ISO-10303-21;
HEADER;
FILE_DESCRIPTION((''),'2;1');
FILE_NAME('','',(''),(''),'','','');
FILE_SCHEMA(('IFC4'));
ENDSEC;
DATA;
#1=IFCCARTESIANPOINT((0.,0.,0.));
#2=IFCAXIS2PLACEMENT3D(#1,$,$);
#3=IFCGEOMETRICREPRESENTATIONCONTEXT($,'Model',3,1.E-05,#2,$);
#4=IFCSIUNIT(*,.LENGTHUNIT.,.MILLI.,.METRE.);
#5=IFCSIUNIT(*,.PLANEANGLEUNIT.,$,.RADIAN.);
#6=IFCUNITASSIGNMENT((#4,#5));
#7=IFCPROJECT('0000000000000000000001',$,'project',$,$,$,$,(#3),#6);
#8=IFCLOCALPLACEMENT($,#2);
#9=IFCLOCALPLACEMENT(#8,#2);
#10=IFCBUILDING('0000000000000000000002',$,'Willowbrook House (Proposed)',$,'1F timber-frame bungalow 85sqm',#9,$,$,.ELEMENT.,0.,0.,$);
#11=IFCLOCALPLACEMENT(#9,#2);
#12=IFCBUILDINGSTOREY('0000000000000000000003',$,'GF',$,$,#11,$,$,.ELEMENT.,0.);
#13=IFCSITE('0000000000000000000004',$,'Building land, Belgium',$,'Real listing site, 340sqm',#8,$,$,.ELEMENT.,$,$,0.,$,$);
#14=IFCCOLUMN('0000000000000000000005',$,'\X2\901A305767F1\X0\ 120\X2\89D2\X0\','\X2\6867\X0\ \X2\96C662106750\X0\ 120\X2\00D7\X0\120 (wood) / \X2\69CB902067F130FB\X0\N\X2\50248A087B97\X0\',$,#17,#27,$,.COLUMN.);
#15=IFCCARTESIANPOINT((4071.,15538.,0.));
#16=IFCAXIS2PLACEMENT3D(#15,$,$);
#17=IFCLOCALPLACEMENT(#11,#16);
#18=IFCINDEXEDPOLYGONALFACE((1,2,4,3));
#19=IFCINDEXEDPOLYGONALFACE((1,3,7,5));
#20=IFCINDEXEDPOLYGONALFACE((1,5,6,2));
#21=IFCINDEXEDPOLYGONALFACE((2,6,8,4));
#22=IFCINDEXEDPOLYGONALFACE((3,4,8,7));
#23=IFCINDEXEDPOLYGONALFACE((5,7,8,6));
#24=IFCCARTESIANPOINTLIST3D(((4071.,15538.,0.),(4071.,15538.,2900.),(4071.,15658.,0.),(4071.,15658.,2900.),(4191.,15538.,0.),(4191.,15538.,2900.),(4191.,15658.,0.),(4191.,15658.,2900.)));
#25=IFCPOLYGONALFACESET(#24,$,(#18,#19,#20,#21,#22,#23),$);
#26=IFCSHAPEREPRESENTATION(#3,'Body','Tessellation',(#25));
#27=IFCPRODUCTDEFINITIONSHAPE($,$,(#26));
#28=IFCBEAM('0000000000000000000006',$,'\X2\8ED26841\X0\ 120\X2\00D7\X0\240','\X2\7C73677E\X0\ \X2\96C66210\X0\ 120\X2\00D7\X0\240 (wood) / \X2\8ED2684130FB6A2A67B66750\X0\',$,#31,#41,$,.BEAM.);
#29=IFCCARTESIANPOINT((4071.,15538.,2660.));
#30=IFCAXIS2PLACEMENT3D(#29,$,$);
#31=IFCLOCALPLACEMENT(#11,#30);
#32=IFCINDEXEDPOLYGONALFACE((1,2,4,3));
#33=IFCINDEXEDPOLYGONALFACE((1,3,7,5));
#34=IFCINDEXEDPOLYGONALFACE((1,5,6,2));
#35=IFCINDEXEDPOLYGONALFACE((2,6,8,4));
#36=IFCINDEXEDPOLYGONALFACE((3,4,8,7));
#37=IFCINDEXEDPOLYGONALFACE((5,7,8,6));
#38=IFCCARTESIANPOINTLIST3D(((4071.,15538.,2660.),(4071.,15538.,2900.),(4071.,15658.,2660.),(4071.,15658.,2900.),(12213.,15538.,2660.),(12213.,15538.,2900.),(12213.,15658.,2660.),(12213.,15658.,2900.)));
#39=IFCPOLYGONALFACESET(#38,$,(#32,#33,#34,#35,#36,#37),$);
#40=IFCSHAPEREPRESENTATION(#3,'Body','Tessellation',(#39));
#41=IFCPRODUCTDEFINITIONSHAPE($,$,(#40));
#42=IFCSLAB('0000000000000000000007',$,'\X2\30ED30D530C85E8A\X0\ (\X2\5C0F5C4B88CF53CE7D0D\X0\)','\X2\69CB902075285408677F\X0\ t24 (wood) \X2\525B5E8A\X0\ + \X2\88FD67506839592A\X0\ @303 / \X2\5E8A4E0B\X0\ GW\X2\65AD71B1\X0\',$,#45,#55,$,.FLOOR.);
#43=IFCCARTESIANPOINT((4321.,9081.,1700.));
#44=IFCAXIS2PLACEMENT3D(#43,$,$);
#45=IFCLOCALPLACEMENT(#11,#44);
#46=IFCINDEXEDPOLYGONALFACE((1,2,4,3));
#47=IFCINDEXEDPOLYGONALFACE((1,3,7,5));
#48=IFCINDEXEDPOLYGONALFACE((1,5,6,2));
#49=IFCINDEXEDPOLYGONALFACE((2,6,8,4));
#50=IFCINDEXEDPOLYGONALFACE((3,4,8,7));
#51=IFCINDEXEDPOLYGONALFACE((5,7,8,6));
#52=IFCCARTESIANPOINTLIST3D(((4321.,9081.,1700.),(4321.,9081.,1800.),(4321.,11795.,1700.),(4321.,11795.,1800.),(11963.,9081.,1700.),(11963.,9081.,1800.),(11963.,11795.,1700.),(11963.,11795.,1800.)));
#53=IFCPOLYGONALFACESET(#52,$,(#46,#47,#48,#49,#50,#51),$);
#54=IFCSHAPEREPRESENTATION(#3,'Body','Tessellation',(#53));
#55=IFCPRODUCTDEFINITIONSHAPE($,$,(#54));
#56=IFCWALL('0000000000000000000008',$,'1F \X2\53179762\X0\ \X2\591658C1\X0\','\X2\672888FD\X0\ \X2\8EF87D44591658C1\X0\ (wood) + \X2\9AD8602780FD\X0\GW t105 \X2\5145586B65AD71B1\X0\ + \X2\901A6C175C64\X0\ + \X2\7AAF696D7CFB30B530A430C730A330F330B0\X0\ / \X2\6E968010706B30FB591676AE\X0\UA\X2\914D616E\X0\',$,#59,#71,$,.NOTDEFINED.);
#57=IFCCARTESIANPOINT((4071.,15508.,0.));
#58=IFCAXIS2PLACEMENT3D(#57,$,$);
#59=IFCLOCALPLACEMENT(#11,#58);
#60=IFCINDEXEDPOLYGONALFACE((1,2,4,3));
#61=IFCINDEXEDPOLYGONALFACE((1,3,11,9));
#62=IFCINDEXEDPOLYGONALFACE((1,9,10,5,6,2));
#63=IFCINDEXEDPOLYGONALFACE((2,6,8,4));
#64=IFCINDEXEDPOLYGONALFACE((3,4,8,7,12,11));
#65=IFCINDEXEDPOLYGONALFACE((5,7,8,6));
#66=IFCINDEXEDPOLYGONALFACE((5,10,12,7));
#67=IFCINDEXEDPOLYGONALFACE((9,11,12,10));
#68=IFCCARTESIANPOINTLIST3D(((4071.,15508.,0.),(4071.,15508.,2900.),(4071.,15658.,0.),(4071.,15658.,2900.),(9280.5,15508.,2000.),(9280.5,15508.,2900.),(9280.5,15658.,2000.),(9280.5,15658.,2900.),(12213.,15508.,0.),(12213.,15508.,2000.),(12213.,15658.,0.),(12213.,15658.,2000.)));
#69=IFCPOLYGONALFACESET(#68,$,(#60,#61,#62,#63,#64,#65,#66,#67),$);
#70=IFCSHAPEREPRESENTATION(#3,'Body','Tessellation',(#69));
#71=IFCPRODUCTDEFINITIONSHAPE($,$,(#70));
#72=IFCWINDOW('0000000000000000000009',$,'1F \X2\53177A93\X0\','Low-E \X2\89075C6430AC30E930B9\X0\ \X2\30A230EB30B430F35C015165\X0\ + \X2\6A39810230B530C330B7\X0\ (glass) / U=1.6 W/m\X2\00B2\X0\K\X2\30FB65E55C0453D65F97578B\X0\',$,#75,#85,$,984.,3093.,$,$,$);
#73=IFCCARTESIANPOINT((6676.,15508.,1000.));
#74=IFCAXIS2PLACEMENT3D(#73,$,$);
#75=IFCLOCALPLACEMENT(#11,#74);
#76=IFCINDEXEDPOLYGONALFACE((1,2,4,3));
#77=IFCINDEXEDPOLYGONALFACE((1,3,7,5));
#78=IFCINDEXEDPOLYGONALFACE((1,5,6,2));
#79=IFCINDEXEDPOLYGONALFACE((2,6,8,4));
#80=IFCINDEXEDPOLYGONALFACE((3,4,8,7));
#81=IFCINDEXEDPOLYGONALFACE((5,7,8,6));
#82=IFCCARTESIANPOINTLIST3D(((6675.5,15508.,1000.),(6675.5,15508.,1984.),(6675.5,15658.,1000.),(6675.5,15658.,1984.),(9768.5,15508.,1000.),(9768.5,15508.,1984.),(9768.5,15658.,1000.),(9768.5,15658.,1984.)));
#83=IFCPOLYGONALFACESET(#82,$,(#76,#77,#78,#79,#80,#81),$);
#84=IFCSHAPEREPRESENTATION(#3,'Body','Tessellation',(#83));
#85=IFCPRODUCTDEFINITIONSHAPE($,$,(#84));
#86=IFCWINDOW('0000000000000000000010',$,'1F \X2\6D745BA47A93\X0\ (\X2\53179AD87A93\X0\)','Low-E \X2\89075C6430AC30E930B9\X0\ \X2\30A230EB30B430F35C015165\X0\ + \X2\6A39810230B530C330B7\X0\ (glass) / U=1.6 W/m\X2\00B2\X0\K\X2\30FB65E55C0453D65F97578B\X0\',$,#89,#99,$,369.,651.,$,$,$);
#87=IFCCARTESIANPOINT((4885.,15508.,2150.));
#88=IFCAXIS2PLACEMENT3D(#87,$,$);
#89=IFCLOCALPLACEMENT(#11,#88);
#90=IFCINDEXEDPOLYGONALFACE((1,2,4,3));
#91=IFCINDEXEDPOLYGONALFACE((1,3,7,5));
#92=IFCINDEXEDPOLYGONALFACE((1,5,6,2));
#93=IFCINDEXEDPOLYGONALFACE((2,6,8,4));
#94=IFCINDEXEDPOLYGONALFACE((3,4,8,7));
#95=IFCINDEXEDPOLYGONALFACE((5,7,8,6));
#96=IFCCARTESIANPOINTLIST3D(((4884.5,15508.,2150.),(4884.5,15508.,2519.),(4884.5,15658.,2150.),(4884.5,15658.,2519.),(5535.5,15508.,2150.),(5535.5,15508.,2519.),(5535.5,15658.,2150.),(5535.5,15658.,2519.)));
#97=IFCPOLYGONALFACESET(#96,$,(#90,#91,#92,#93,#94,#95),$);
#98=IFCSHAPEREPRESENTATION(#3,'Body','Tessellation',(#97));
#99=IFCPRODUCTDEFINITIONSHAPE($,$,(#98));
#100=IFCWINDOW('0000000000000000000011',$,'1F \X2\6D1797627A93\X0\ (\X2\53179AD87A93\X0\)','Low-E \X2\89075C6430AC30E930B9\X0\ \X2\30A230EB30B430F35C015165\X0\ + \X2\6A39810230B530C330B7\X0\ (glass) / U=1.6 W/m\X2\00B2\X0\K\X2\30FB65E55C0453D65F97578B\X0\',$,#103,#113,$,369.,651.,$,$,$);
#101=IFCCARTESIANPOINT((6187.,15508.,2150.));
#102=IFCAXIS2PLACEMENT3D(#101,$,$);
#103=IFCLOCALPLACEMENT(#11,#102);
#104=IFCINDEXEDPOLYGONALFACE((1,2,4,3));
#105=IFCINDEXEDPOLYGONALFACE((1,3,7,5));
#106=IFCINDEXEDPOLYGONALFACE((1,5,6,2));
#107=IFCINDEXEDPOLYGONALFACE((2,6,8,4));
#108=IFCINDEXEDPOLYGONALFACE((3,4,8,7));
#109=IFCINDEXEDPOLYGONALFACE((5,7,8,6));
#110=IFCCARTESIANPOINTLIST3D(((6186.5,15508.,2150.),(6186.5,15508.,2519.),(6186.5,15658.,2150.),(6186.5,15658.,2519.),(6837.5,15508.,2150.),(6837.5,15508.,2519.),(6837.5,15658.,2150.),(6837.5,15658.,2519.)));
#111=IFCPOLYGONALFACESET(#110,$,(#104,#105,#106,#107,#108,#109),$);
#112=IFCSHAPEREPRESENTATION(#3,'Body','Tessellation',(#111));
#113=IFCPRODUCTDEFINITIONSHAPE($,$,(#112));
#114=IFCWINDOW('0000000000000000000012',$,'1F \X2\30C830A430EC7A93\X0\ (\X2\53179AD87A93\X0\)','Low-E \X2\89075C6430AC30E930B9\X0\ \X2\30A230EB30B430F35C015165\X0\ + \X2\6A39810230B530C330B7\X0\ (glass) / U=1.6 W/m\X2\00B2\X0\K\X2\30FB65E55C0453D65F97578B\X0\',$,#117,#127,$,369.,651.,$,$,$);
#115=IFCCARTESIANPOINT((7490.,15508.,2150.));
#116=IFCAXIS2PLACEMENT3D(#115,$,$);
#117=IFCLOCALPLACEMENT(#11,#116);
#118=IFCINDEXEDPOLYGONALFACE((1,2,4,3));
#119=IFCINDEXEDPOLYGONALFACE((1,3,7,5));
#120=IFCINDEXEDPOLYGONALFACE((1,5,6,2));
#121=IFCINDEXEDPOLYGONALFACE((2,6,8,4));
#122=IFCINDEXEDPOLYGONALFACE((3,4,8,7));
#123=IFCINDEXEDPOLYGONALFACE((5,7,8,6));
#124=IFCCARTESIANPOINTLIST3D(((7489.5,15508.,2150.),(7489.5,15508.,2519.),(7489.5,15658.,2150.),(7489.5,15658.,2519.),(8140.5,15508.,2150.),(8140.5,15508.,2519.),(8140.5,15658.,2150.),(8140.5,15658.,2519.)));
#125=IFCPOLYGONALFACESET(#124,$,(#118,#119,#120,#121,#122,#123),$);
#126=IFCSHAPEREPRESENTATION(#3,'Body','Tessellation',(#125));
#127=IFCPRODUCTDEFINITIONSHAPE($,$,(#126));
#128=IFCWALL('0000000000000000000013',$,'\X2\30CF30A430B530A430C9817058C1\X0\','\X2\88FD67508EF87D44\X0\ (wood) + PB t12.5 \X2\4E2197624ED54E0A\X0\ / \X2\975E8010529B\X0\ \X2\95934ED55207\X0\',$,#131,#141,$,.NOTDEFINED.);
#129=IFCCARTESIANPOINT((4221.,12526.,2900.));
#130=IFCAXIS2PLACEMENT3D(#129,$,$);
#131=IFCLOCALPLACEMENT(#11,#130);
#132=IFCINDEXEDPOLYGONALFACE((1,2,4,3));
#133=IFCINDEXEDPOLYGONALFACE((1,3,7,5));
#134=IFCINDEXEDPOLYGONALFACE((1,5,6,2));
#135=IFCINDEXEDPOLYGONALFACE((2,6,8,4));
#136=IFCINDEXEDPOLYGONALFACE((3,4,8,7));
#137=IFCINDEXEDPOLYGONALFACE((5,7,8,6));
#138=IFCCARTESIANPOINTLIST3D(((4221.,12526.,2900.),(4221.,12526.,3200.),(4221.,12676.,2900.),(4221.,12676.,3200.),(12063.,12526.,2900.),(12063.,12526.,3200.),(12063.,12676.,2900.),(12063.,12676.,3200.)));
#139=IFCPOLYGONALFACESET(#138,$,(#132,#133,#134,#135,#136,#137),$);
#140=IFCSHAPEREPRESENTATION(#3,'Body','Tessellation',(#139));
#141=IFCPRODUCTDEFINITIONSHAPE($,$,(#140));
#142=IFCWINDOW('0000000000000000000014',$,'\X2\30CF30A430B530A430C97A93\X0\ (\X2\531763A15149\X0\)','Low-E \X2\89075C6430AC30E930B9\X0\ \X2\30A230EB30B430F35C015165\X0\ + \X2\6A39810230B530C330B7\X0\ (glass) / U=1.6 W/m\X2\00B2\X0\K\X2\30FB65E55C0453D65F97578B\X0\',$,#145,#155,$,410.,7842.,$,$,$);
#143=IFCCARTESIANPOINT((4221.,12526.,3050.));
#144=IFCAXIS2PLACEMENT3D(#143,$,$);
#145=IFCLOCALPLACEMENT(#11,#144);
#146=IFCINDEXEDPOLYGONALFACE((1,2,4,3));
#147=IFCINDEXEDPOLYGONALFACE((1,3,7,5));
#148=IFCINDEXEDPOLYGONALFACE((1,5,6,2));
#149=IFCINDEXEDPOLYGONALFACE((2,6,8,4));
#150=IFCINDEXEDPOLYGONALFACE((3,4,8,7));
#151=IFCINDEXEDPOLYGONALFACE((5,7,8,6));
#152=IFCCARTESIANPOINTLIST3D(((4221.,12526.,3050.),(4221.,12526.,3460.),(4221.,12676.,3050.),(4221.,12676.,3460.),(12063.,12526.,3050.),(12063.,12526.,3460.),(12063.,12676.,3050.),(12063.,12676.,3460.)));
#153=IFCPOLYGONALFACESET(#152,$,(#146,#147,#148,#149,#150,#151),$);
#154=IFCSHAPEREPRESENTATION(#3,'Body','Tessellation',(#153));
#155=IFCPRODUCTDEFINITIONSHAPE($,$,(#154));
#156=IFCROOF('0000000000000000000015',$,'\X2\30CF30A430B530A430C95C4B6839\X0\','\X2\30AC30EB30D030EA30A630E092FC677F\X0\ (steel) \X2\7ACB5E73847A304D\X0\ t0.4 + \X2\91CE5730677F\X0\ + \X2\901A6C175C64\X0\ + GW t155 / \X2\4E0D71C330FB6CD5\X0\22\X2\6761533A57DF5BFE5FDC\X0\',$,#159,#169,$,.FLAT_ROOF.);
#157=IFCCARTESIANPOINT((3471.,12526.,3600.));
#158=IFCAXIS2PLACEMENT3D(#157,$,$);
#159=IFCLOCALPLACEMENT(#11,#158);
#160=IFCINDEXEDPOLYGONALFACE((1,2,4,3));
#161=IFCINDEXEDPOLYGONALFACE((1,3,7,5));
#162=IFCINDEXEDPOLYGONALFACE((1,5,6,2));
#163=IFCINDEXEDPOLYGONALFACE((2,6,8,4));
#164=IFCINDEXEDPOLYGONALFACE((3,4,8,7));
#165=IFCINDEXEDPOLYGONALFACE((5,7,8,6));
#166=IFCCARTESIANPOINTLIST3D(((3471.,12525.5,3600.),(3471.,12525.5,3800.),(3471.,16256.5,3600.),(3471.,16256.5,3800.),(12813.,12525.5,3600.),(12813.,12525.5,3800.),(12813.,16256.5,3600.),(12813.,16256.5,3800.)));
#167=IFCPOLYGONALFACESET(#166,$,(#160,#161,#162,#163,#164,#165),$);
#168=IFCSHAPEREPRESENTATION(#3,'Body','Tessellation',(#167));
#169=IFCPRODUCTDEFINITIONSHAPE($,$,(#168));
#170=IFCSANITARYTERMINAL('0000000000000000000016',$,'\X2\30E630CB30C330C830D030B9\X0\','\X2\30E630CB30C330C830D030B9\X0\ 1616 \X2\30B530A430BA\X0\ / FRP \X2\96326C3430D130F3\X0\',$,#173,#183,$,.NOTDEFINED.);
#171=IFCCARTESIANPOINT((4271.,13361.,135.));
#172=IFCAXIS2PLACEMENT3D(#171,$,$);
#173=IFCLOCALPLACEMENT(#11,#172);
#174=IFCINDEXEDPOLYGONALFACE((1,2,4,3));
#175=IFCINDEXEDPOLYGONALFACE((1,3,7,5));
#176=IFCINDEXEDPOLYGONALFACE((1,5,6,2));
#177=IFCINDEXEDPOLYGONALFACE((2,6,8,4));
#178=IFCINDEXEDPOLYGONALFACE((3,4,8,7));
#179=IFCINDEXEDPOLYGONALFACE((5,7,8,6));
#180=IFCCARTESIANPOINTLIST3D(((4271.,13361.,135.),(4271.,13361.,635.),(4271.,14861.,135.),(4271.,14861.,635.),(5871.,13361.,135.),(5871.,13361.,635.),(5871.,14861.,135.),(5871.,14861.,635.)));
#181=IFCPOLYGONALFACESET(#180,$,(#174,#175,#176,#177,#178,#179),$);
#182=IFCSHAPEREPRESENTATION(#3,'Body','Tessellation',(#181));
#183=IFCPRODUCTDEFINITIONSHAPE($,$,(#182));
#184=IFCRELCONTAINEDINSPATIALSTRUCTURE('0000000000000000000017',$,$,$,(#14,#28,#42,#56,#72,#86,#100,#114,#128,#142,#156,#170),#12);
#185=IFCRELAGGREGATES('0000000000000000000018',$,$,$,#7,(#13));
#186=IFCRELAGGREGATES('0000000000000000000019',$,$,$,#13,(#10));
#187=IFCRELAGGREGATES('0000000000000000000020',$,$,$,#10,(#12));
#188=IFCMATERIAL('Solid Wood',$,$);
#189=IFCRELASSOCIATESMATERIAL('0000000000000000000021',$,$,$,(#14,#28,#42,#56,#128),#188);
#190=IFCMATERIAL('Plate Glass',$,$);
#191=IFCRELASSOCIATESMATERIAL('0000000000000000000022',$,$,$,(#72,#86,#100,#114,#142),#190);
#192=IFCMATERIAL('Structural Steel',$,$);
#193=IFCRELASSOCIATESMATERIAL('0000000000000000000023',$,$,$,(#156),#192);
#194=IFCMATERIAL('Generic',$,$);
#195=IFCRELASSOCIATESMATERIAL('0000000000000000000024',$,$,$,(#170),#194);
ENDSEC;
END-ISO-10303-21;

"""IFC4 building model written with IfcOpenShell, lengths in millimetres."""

from ifc_helpers import new_model, si_unit, frame, frame_2d, origin, place, context, project, spatial, rectangle, extrude, material, element, fill, save


model = new_model("IFC4")

# Units and contexts
model_context = context("Model", 3, precision=1e-05, world=origin())
ifc_project = project(units=[si_unit("LENGTHUNIT", "METRE", prefix="MILLI"), si_unit("PLANEANGLEUNIT", "RADIAN")], contexts=[model_context])

# Site, building, storey
site_placement = place(None, origin())
site = spatial("IfcSite", under=ifc_project, at=site_placement, Name="Building land, Belgium", ObjectType="Real listing site, 340sqm", CompositionType="ELEMENT", RefElevation=0.0)
building_placement = place(site_placement, origin())
building = spatial("IfcBuilding", under=site, at=building_placement, Name="Willowbrook House (Proposed)", ObjectType="1F timber-frame bungalow 85sqm", CompositionType="ELEMENT", ElevationOfRefHeight=0.0, ElevationOfTerrain=0.0)
storey_placement = place(building_placement, origin())
storey = spatial("IfcBuildingStorey", under=building, at=storey_placement, Name="GF", CompositionType="ELEMENT", Elevation=0.0)

# Column
ifc_material_1 = material(Name="Solid Wood")
column_1_placement = place(storey_placement, frame((4071.0, 15538.0, 0.0)))
element("IfcColumn", 1, at=column_1_placement, inside=storey, material=ifc_material_1, Name="通し柱 120角", Description="桧 集成材 120×120 (wood) / 構造柱・N値計算", PredefinedType="COLUMN", context=model_context, shape_type="SweptSolid", body=[
    extrude(rectangle(XDim=120.0, YDim=120.0, at=frame_2d((60.0, 60.0))), frame((4071.0, 15538.0, 0.0)), (0.0, 0.0, 1.0), 2900.0),
])

# Beam
beam_1_placement = place(storey_placement, frame((4071.0, 15538.0, 2660.0)))
element("IfcBeam", 2, at=beam_1_placement, inside=storey, material=ifc_material_1, Name="軒桁 120×240", Description="米松 集成 120×240 (wood) / 軒桁・横架材", PredefinedType="BEAM", context=model_context, shape_type="SweptSolid", body=[
    extrude(rectangle(XDim=8142.0, YDim=120.0, at=frame_2d((4071.0, 60.0))), frame((4071.0, 15538.0, 2660.0)), (0.0, 0.0, 1.0), 240.0),
])

# Slab
slab_placement = place(storey_placement, frame((4321.0, 9081.0, 1700.0)))
element("IfcSlab", 3, at=slab_placement, inside=storey, material=ifc_material_1, Name="ロフト床 (小屋裏収納)", Description="構造用合板 t24 (wood) 剛床 + 製材根太 @303 / 床下 GW断熱", PredefinedType="FLOOR", context=model_context, shape_type="SweptSolid", body=[
    extrude(rectangle(XDim=7642.0, YDim=2714.0, at=frame_2d((3821.0, 1357.0))), frame((4321.0, 9081.0, 1700.0)), (0.0, 0.0, 1.0), 100.0),
])

# Wall, openings, windows
wall_1_placement = place(storey_placement, frame((4071.0, 15508.0, 0.0)))
wall_1 = element("IfcWall", 4, at=wall_1_placement, inside=storey, material=ifc_material_1, Name="1F 北面 外壁", Description="木製 軸組外壁 (wood) + 高性能GW t105 充填断熱 + 通気層 + 窯業系サイディング / 準耐火・外皮UA配慮", PredefinedType="NOTDEFINED", context=model_context, shape_type="SweptSolid", body=[
    extrude(rectangle(XDim=8142.0, YDim=150.0, at=frame_2d((4071.0, 75.0))), frame((4071.0, 15508.0, 0.0)), (0.0, 0.0, 1.0), 2900.0),
])
opening_1_placement = place(storey_placement, frame((6676.0, 15508.0, 1000.0)))
opening_1 = element("IfcOpeningElement", 5, at=opening_1_placement, cuts=wall_1, PredefinedType="NOTDEFINED", context=model_context, shape_type="SweptSolid", body=[
    extrude(rectangle(XDim=3093.0, YDim=150.0, at=frame_2d((1546.0, 75.0))), frame((6676.0, 15508.0, 1000.0)), (0.0, 0.0, 1.0), 984.0),
])
opening_2_placement = place(storey_placement, frame((4885.0, 15508.0, 2150.0)))
opening_2 = element("IfcOpeningElement", 6, at=opening_2_placement, cuts=wall_1, PredefinedType="NOTDEFINED", context=model_context, shape_type="SweptSolid", body=[
    extrude(rectangle(XDim=651.0, YDim=150.0, at=frame_2d((325.0, 75.0))), frame((4885.0, 15508.0, 2150.0)), (0.0, 0.0, 1.0), 369.0),
])
opening_3_placement = place(storey_placement, frame((6187.0, 15508.0, 2150.0)))
opening_3 = element("IfcOpeningElement", 7, at=opening_3_placement, cuts=wall_1, PredefinedType="NOTDEFINED", context=model_context, shape_type="SweptSolid", body=[
    extrude(rectangle(XDim=651.0, YDim=150.0, at=frame_2d((325.0, 75.0))), frame((6187.0, 15508.0, 2150.0)), (0.0, 0.0, 1.0), 369.0),
])
opening_4_placement = place(storey_placement, frame((7490.0, 15508.0, 2150.0)))
opening_4 = element("IfcOpeningElement", 8, at=opening_4_placement, cuts=wall_1, PredefinedType="NOTDEFINED", context=model_context, shape_type="SweptSolid", body=[
    extrude(rectangle(XDim=651.0, YDim=150.0, at=frame_2d((325.0, 75.0))), frame((7490.0, 15508.0, 2150.0)), (0.0, 0.0, 1.0), 369.0),
])
ifc_material_2 = material(Name="Plate Glass")
window_1_placement = place(storey_placement, frame((6676.0, 15508.0, 1000.0)))
window_1 = element("IfcWindow", 9, at=window_1_placement, inside=storey, material=ifc_material_2, Name="1F 北窓", Description="Low-E 複層ガラス アルゴン封入 + 樹脂サッシ (glass) / U=1.6 W/m²K・日射取得型", OverallHeight=984.0, OverallWidth=3093.0, context=model_context, shape_type="SweptSolid", body=[
    extrude(rectangle(XDim=3093.0, YDim=150.0, at=frame_2d((1546.0, 75.0))), frame((6676.0, 15508.0, 1000.0)), (0.0, 0.0, 1.0), 984.0),
])
fill(opening_1, window_1)
window_2_placement = place(storey_placement, frame((4885.0, 15508.0, 2150.0)))
window_2 = element("IfcWindow", 10, at=window_2_placement, inside=storey, material=ifc_material_2, Name="1F 浴室窓 (北高窓)", Description="Low-E 複層ガラス アルゴン封入 + 樹脂サッシ (glass) / U=1.6 W/m²K・日射取得型", OverallHeight=369.0, OverallWidth=651.0, context=model_context, shape_type="SweptSolid", body=[
    extrude(rectangle(XDim=651.0, YDim=150.0, at=frame_2d((325.0, 75.0))), frame((4885.0, 15508.0, 2150.0)), (0.0, 0.0, 1.0), 369.0),
])
fill(opening_2, window_2)
window_3_placement = place(storey_placement, frame((6187.0, 15508.0, 2150.0)))
window_3 = element("IfcWindow", 11, at=window_3_placement, inside=storey, material=ifc_material_2, Name="1F 洗面窓 (北高窓)", Description="Low-E 複層ガラス アルゴン封入 + 樹脂サッシ (glass) / U=1.6 W/m²K・日射取得型", OverallHeight=369.0, OverallWidth=651.0, context=model_context, shape_type="SweptSolid", body=[
    extrude(rectangle(XDim=651.0, YDim=150.0, at=frame_2d((325.0, 75.0))), frame((6187.0, 15508.0, 2150.0)), (0.0, 0.0, 1.0), 369.0),
])
fill(opening_3, window_3)
window_4_placement = place(storey_placement, frame((7490.0, 15508.0, 2150.0)))
window_4 = element("IfcWindow", 12, at=window_4_placement, inside=storey, material=ifc_material_2, Name="1F トイレ窓 (北高窓)", Description="Low-E 複層ガラス アルゴン封入 + 樹脂サッシ (glass) / U=1.6 W/m²K・日射取得型", OverallHeight=369.0, OverallWidth=651.0, context=model_context, shape_type="SweptSolid", body=[
    extrude(rectangle(XDim=651.0, YDim=150.0, at=frame_2d((325.0, 75.0))), frame((7490.0, 15508.0, 2150.0)), (0.0, 0.0, 1.0), 369.0),
])
fill(opening_4, window_4)

# Wall, opening, window
wall_2_placement = place(storey_placement, frame((4221.0, 12526.0, 2900.0)))
wall_2 = element("IfcWall", 13, at=wall_2_placement, inside=storey, material=ifc_material_1, Name="ハイサイド腰壁", Description="製材軸組 (wood) + PB t12.5 両面仕上 / 非耐力 間仕切", PredefinedType="NOTDEFINED", context=model_context, shape_type="SweptSolid", body=[
    extrude(rectangle(XDim=7842.0, YDim=150.0, at=frame_2d((3921.0, 75.0))), frame((4221.0, 12526.0, 2900.0)), (0.0, 0.0, 1.0), 700.0),
])
opening_5_placement = place(storey_placement, frame((4221.0, 12526.0, 3050.0)))
opening_5 = element("IfcOpeningElement", 14, at=opening_5_placement, cuts=wall_2, PredefinedType="NOTDEFINED", context=model_context, shape_type="SweptSolid", body=[
    extrude(rectangle(XDim=7842.0, YDim=150.0, at=frame_2d((3921.0, 75.0))), frame((4221.0, 12526.0, 3050.0)), (0.0, 0.0, 1.0), 410.0),
])
window_5_placement = place(storey_placement, frame((4221.0, 12526.0, 3050.0)))
window_5 = element("IfcWindow", 15, at=window_5_placement, inside=storey, material=ifc_material_2, Name="ハイサイド窓 (北採光)", Description="Low-E 複層ガラス アルゴン封入 + 樹脂サッシ (glass) / U=1.6 W/m²K・日射取得型", OverallHeight=410.0, OverallWidth=7842.0, context=model_context, shape_type="SweptSolid", body=[
    extrude(rectangle(XDim=7842.0, YDim=150.0, at=frame_2d((3921.0, 75.0))), frame((4221.0, 12526.0, 3050.0)), (0.0, 0.0, 1.0), 410.0),
])
fill(opening_5, window_5)

# Roof
ifc_material_3 = material(Name="Structural Steel")
roof_placement = place(storey_placement, frame((3471.0, 12526.0, 3600.0)))
element("IfcRoof", 16, at=roof_placement, inside=storey, material=ifc_material_3, Name="ハイサイド屋根", Description="ガルバリウム鋼板 (steel) 立平葺き t0.4 + 野地板 + 通気層 + GW t155 / 不燃・法22条区域対応", PredefinedType="FLAT_ROOF", context=model_context, shape_type="SweptSolid", body=[
    extrude(rectangle(XDim=9342.0, YDim=3731.0, at=frame_2d((4671.0, 1865.0))), frame((3471.0, 12526.0, 3600.0)), (0.0, 0.0, 1.0), 200.0),
])

# Sanitary terminal
ifc_material_4 = material(Name="Generic")
sanitary_terminal_placement = place(storey_placement, frame((4271.0, 13361.0, 135.0)))
element("IfcSanitaryTerminal", 17, at=sanitary_terminal_placement, inside=storey, material=ifc_material_4, Name="ユニットバス", Description="ユニットバス 1616 サイズ / FRP 防水パン", PredefinedType="NOTDEFINED", context=model_context, shape_type="SweptSolid", body=[
    extrude(rectangle(XDim=1600.0, YDim=1500.0, at=frame_2d((800.0, 750.0))), frame((4271.0, 13361.0, 135.0)), (0.0, 0.0, 1.0), 500.0),
])

save(model, "model.ifc")
